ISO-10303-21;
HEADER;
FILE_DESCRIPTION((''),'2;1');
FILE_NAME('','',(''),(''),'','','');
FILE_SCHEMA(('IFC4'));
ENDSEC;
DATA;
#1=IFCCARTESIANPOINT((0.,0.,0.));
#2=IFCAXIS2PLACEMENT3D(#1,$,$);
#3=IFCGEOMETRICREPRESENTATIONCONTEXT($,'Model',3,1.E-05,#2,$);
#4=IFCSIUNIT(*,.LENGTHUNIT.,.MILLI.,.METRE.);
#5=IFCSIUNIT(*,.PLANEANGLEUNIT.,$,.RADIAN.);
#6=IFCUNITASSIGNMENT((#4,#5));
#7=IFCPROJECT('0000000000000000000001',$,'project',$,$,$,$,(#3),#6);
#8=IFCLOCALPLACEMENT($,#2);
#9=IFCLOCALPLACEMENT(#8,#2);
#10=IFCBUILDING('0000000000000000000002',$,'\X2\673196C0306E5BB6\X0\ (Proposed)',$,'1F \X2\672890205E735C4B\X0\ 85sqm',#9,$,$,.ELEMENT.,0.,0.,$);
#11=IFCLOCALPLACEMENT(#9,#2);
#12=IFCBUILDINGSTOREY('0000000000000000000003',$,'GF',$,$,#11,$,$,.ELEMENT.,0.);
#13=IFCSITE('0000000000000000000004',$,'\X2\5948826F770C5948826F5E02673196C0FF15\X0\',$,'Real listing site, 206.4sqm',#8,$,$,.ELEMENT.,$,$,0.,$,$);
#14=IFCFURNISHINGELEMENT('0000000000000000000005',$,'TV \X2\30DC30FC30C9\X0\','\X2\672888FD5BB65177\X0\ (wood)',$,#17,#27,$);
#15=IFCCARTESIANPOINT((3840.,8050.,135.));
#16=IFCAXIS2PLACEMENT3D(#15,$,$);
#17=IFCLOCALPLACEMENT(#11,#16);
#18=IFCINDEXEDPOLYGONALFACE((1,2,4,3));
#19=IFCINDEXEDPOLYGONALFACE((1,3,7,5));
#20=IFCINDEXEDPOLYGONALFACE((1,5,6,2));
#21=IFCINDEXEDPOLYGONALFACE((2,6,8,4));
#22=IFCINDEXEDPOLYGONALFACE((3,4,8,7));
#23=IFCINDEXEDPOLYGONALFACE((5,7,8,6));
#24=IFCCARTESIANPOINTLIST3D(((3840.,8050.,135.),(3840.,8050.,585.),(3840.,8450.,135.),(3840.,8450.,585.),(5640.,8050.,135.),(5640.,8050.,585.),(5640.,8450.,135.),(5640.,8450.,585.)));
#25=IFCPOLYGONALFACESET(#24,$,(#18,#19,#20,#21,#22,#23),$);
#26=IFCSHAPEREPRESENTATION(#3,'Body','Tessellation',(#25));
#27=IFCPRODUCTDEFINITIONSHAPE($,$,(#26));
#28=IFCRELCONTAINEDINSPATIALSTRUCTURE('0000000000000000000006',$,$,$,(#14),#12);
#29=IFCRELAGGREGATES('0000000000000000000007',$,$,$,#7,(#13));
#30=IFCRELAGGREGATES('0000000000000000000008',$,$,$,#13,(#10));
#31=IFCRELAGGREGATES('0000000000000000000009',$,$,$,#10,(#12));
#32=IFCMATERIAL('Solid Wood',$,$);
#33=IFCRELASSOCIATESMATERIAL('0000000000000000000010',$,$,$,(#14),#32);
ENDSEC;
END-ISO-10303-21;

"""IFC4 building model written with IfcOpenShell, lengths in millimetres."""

from ifc_helpers import new_model, si_unit, frame, frame_2d, origin, place, context, project, spatial, rectangle, extrude, material, element, save


model = new_model("IFC4")

# Units and contexts
model_context = context("Model", 3, precision=1e-05, world=origin())
ifc_project = project(units=[si_unit("LENGTHUNIT", "METRE", prefix="MILLI"), si_unit("PLANEANGLEUNIT", "RADIAN")], contexts=[model_context])

# Site, building, storey
site_placement = place(None, origin())
site = spatial("IfcSite", under=ifc_project, at=site_placement, Name="奈良県奈良市朱雀５", ObjectType="Real listing site, 206.4sqm", CompositionType="ELEMENT", RefElevation=0.0)
building_placement = place(site_placement, origin())
building = spatial("IfcBuilding", under=site, at=building_placement, Name="朱雀の家 (Proposed)", ObjectType="1F 木造平屋 85sqm", CompositionType="ELEMENT", ElevationOfRefHeight=0.0, ElevationOfTerrain=0.0)
storey_placement = place(building_placement, origin())
storey = spatial("IfcBuildingStorey", under=building, at=storey_placement, Name="GF", CompositionType="ELEMENT", Elevation=0.0)

# Shared definitions
ifc_material_1 = material(Name="Solid Wood")

# Furnishing element
furnishing_placement = place(storey_placement, frame((3840.0, 8050.0, 135.0)))
element("IfcFurnishingElement", 1, at=furnishing_placement, inside=storey, material=ifc_material_1, Name="TV ボード", Description="木製家具 (wood)", context=model_context, shape_type="SweptSolid", body=[
    extrude(rectangle(XDim=1800.0, YDim=400.0, at=frame_2d((900.0, 200.0))), frame((3840.0, 8050.0, 135.0)), (0.0, 0.0, 1.0), 450.0),
])

save(model, "model.ifc")
